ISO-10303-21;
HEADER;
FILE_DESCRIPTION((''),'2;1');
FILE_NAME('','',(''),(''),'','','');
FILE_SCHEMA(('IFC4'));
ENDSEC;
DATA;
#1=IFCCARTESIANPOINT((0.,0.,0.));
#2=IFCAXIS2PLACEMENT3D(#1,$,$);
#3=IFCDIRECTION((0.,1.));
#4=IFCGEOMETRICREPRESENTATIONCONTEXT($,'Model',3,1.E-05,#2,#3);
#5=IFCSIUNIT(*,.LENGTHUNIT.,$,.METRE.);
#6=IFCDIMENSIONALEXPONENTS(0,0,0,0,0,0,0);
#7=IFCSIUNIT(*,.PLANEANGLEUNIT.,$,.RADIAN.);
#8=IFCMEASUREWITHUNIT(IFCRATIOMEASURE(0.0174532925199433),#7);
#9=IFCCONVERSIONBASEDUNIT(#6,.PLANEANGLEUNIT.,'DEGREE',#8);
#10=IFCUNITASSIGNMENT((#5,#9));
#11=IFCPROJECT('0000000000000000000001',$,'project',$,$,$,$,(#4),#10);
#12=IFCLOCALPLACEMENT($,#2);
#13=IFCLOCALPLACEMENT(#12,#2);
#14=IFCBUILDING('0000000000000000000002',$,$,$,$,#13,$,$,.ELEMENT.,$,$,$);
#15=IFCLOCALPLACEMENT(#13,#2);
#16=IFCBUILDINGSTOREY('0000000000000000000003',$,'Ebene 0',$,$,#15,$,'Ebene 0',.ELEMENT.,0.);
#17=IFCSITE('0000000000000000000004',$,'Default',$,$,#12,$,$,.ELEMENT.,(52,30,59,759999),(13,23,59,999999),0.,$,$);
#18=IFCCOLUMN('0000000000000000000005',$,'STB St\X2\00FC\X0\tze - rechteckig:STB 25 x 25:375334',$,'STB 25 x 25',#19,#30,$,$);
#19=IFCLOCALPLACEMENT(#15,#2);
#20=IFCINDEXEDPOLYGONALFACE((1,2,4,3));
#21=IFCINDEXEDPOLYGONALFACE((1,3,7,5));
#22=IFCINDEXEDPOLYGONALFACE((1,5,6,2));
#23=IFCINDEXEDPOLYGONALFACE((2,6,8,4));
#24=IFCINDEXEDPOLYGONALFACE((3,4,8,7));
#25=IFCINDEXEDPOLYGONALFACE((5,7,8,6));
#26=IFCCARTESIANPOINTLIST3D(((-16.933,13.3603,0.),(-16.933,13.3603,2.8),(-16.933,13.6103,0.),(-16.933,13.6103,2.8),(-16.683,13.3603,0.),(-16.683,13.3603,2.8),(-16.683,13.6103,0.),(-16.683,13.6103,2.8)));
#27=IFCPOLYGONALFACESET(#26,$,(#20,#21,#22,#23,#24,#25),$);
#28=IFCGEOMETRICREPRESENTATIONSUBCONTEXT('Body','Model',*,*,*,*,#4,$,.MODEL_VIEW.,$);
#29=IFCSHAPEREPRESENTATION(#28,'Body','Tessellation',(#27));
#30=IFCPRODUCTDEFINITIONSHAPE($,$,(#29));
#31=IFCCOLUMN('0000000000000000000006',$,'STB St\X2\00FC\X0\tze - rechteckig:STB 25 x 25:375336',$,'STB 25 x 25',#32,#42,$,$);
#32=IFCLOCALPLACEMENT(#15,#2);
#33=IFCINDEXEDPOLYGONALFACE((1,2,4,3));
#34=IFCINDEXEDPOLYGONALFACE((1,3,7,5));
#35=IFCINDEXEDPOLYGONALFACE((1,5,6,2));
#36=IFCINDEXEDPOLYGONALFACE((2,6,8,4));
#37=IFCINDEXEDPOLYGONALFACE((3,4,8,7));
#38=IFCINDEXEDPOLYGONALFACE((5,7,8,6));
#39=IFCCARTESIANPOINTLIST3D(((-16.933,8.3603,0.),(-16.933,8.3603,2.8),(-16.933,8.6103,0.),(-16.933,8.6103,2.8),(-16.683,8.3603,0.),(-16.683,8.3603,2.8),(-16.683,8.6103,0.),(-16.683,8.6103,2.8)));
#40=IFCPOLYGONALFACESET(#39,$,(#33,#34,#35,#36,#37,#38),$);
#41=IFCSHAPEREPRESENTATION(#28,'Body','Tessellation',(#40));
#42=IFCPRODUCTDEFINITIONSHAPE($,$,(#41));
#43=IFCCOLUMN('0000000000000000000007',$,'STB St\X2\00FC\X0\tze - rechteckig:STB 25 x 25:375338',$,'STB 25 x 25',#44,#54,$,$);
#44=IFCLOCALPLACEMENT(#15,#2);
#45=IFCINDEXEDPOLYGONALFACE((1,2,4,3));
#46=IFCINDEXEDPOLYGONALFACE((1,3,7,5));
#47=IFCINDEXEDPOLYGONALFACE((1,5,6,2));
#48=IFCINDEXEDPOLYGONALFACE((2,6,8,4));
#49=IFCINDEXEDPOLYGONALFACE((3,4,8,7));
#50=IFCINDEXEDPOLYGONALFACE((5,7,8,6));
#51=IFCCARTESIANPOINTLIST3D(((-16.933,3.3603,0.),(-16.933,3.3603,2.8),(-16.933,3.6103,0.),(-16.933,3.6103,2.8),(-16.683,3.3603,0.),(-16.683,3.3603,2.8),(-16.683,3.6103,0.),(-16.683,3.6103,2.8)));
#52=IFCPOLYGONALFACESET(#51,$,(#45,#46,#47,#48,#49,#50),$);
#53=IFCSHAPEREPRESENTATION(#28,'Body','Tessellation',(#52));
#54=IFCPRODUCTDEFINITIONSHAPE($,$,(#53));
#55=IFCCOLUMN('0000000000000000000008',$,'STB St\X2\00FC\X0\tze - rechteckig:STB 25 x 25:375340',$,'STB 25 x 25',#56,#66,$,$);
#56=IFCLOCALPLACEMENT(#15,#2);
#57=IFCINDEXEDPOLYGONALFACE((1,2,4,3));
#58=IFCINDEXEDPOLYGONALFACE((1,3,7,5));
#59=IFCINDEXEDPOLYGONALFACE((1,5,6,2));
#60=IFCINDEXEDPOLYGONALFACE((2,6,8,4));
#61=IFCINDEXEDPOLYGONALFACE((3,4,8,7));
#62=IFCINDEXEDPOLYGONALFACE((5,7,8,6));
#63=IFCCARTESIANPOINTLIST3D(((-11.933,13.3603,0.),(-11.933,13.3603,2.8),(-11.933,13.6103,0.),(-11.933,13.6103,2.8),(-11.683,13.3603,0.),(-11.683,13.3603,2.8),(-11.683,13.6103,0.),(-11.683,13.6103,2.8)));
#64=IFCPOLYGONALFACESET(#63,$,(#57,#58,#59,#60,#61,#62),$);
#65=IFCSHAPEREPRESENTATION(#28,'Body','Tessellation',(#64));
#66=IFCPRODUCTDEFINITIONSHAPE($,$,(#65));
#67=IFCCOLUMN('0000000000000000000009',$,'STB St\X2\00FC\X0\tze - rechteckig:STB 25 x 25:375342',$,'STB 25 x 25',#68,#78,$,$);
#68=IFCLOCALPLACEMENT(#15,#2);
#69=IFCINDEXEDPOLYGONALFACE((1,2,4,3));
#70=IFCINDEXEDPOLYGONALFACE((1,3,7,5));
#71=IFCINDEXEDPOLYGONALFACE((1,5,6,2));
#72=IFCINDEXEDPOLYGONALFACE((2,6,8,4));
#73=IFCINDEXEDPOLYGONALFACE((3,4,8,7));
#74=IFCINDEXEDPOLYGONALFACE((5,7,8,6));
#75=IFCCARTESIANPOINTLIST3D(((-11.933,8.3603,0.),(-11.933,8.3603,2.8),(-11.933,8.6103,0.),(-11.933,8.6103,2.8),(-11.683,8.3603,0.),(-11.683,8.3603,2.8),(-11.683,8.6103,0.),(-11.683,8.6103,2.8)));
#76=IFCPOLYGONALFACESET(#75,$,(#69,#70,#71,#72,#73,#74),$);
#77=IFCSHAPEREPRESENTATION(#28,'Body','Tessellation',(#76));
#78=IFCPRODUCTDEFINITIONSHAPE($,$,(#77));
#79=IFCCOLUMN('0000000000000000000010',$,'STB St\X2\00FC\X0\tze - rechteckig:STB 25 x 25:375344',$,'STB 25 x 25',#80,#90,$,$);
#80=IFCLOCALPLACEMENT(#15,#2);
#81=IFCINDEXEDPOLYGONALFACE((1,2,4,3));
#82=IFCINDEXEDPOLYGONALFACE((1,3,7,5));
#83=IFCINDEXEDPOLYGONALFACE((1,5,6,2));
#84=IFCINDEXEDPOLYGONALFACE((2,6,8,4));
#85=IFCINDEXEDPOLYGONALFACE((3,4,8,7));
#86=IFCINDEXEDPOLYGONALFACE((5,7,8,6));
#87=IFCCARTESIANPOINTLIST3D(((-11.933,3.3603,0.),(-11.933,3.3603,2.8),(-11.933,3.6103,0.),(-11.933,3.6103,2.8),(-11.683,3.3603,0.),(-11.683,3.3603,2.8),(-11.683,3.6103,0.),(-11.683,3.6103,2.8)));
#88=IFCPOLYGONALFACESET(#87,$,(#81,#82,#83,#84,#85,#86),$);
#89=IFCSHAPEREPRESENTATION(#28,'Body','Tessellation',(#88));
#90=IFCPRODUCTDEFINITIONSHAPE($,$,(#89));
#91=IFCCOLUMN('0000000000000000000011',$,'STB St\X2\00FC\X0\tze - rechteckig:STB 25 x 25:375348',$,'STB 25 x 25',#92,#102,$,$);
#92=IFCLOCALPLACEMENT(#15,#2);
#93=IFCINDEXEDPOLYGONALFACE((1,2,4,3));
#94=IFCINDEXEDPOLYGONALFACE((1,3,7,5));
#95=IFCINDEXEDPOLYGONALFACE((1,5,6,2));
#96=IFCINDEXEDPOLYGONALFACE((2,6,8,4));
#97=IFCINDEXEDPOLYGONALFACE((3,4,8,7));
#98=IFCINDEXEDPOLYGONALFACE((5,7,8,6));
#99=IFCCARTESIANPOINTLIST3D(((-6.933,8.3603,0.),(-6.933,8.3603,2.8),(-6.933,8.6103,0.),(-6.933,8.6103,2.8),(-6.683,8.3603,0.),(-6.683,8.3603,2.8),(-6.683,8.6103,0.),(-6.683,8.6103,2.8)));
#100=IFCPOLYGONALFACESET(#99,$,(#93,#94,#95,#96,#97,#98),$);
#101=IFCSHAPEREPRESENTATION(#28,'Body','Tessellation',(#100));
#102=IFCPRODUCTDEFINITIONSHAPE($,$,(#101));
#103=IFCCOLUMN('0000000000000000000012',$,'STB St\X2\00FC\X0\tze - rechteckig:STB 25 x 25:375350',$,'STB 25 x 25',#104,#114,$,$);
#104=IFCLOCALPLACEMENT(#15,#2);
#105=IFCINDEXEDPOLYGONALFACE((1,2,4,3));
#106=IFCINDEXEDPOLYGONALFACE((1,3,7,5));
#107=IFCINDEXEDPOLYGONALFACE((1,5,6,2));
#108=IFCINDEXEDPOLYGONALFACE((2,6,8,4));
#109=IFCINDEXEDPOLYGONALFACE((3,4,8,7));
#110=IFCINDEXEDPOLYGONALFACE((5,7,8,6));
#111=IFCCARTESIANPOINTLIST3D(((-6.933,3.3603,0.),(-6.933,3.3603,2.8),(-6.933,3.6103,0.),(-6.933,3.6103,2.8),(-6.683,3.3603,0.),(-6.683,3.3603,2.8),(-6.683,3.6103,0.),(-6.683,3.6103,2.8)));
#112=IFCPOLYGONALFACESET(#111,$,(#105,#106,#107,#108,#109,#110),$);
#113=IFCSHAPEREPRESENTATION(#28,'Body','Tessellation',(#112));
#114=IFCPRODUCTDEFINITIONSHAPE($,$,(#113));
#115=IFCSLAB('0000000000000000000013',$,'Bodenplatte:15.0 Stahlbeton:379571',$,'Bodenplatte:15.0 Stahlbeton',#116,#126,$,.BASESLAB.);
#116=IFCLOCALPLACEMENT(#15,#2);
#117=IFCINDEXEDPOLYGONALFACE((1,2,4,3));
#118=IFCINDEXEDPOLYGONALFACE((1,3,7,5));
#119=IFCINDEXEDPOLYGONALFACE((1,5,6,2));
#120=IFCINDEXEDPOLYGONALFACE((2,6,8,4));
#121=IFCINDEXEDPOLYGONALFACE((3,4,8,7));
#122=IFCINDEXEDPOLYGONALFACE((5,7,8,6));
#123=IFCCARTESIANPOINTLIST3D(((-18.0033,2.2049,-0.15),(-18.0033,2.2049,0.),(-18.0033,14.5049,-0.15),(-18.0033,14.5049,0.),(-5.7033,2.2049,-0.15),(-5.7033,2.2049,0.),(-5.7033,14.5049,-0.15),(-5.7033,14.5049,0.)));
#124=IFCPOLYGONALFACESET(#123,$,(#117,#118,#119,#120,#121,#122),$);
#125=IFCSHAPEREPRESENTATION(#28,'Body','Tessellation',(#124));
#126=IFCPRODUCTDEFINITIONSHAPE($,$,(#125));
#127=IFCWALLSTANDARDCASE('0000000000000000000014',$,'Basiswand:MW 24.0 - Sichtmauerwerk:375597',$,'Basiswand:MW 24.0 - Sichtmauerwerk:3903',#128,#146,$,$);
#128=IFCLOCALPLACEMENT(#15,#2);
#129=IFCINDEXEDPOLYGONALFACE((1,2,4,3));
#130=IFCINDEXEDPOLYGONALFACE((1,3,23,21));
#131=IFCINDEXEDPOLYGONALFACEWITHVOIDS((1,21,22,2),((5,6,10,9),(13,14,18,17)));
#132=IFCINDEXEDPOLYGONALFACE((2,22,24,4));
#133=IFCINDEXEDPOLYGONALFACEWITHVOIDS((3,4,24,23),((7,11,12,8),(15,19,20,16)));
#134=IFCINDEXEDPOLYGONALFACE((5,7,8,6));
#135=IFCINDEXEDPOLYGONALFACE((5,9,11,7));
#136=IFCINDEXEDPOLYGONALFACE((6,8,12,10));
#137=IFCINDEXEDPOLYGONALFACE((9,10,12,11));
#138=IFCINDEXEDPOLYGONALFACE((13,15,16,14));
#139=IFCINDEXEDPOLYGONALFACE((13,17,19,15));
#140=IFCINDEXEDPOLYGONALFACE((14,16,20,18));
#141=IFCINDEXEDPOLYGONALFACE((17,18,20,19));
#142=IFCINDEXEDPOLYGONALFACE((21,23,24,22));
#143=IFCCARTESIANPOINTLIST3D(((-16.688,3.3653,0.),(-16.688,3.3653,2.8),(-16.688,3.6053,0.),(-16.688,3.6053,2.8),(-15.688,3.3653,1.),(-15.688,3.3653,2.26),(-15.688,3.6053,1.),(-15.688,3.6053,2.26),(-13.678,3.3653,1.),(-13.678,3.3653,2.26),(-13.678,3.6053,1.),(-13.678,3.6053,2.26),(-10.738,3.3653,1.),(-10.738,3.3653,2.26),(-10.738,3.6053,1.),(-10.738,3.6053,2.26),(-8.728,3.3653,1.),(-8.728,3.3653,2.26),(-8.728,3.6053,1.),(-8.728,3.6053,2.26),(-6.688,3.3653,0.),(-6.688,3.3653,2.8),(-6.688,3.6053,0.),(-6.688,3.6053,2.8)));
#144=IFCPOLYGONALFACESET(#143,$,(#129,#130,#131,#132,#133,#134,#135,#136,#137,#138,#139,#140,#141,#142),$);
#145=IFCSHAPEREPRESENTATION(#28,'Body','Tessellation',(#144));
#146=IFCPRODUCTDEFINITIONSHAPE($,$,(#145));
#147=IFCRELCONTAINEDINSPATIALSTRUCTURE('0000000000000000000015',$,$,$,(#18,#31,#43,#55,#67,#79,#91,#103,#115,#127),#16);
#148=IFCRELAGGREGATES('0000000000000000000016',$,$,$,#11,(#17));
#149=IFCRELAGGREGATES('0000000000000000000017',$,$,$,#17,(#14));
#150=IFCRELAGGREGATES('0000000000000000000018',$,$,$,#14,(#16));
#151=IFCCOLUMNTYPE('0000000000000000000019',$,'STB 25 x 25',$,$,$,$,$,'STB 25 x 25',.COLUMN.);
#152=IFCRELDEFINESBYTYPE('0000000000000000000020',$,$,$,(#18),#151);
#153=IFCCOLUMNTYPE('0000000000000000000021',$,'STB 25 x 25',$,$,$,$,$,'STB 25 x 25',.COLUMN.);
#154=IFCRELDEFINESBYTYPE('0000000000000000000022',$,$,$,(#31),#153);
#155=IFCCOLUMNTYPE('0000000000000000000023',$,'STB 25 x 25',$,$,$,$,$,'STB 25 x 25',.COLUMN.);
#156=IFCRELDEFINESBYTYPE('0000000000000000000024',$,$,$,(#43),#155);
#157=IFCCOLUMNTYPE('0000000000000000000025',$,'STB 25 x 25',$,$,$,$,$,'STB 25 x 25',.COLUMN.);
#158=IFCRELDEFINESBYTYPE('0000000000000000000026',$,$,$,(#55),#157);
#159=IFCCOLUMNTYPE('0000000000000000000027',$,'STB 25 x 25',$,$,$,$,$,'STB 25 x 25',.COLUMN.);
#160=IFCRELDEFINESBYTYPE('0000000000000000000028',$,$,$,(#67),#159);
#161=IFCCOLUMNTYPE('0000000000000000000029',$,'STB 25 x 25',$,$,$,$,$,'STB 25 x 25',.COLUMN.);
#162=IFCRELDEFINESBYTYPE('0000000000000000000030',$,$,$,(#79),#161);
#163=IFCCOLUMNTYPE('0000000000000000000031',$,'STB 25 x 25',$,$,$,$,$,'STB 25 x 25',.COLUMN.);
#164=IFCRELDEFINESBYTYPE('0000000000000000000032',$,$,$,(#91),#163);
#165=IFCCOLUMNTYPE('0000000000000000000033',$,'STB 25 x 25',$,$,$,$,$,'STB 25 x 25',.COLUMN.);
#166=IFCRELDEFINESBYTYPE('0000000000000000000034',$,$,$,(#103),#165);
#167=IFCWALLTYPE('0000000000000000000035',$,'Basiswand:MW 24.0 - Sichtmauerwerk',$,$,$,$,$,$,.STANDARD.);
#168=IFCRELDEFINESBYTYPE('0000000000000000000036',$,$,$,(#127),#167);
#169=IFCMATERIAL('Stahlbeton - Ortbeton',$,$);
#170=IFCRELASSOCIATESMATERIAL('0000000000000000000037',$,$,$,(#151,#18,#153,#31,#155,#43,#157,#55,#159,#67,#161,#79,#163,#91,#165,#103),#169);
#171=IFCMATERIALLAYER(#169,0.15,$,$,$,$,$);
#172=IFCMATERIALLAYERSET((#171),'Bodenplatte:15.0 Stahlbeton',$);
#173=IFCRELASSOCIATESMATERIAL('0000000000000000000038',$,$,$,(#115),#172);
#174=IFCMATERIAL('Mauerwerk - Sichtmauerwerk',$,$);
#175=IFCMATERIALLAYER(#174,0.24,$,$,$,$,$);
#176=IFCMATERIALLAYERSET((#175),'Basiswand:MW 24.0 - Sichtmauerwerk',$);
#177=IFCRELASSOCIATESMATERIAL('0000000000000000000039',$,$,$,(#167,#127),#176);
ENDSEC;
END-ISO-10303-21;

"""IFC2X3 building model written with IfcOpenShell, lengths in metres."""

from ifc_helpers import new_model, entity, si_unit, converted_unit, direction, frame, frame_2d, origin, origin_2d_with_axis, place, context, subcontext, project, spatial, polyline, rectangle, extrude, clip, bounded_halfspace, source, transform, mapped, material, layer, layer_set, layer_usage, type_object, type_shapes, element, save


model = new_model("IFC2X3")

# Units and contexts
model_context = context("Model", 3, precision=1e-05, world=origin(), true_north=direction((0.0, 1.0)))
body_context = subcontext(model_context, "Body", "Model", "MODEL_VIEW")
ifc_project = project(units=[si_unit("LENGTHUNIT", "METRE"), converted_unit("PLANEANGLEUNIT", "DEGREE", entity("IfcRatioMeasure", 0.0174532925199433), si_unit("PLANEANGLEUNIT", "RADIAN"), dimensions=[0, 0, 0, 0, 0, 0, 0])], contexts=[model_context])

# Site, building, storey
site_placement = place(None, origin())
site = spatial("IfcSite", under=ifc_project, at=site_placement, Name="Default", CompositionType="ELEMENT", RefLatitude=(52, 30, 59, 759999), RefLongitude=(13, 23, 59, 999999), RefElevation=0.0)
building_placement = place(site_placement, origin())
building = spatial("IfcBuilding", under=site, at=building_placement, CompositionType="ELEMENT")
storey_placement = place(building_placement, origin())
storey = spatial("IfcBuildingStorey", under=building, at=storey_placement, Name="Ebene 0", LongName="Ebene 0", CompositionType="ELEMENT", Elevation=0.0)

# Columns
ifc_material_1 = material(Name="Stahlbeton - Ortbeton")
column_type_1 = type_object("IfcColumnType", Name="STB 25 x 25", ElementType="STB 25 x 25", PredefinedType="COLUMN", material=ifc_material_1)
shared_shape_1 = source(origin(), body_context, "Body", "SweptSolid", [
    extrude(rectangle(XDim=0.25, YDim=0.25, at=origin_2d_with_axis()), frame((-16.808, 13.4853, 0.0), z_axis=(0.0, 0.0, 1.0), x_axis=(0.0, -1.0, 0.0)), (0.0, 0.0, 1.0), 2.8),
])
type_shapes(column_type_1, [shared_shape_1])
column_1_placement = place(storey_placement, origin())
element("IfcColumn", 1, at=column_1_placement, inside=storey, type_object=column_type_1, material=ifc_material_1, Name="STB Stütze - rechteckig:STB 25 x 25:375334", ObjectType="STB 25 x 25", context=body_context, shape_type="MappedRepresentation", body=[
    mapped(shared_shape_1, transform((0.0, 0.0, 0.0), scale=1.0)),
])
column_type_2 = type_object("IfcColumnType", Name="STB 25 x 25", ElementType="STB 25 x 25", PredefinedType="COLUMN", material=ifc_material_1)
shared_shape_2 = source(origin(), body_context, "Body", "SweptSolid", [
    extrude(rectangle(XDim=0.25, YDim=0.25, at=origin_2d_with_axis()), frame((-16.808, 8.4853, 0.0), z_axis=(0.0, 0.0, 1.0), x_axis=(0.0, -1.0, 0.0)), (0.0, 0.0, 1.0), 2.8),
])
type_shapes(column_type_2, [shared_shape_2])
column_2_placement = place(storey_placement, origin())
element("IfcColumn", 2, at=column_2_placement, inside=storey, type_object=column_type_2, material=ifc_material_1, Name="STB Stütze - rechteckig:STB 25 x 25:375336", ObjectType="STB 25 x 25", context=body_context, shape_type="MappedRepresentation", body=[
    mapped(shared_shape_2, transform((0.0, 0.0, 0.0), scale=1.0)),
])
column_type_3 = type_object("IfcColumnType", Name="STB 25 x 25", ElementType="STB 25 x 25", PredefinedType="COLUMN", material=ifc_material_1)
shared_shape_3 = source(origin(), body_context, "Body", "SweptSolid", [
    extrude(rectangle(XDim=0.25, YDim=0.25, at=frame_2d((0.0, 0.0), x_axis=(1.0, 0.0))), frame((-16.808, 3.4853, 0.0), z_axis=(0.0, 0.0, 1.0), x_axis=(0.0, -1.0, 0.0)), (0.0, 0.0, 1.0), 2.8),
])
type_shapes(column_type_3, [shared_shape_3])
column_3_placement = place(storey_placement, origin())
element("IfcColumn", 3, at=column_3_placement, inside=storey, type_object=column_type_3, material=ifc_material_1, Name="STB Stütze - rechteckig:STB 25 x 25:375338", ObjectType="STB 25 x 25", context=body_context, shape_type="MappedRepresentation", body=[
    mapped(shared_shape_3, transform((0.0, 0.0, 0.0), scale=1.0)),
])
column_type_4 = type_object("IfcColumnType", Name="STB 25 x 25", ElementType="STB 25 x 25", PredefinedType="COLUMN", material=ifc_material_1)
shared_shape_4 = source(origin(), body_context, "Body", "SweptSolid", [
    extrude(rectangle(XDim=0.25, YDim=0.25, at=origin_2d_with_axis()), frame((-11.808, 13.4853, 0.0), z_axis=(0.0, 0.0, 1.0), x_axis=(0.0, -1.0, 0.0)), (0.0, 0.0, 1.0), 2.8),
])
type_shapes(column_type_4, [shared_shape_4])
column_4_placement = place(storey_placement, origin())
element("IfcColumn", 4, at=column_4_placement, inside=storey, type_object=column_type_4, material=ifc_material_1, Name="STB Stütze - rechteckig:STB 25 x 25:375340", ObjectType="STB 25 x 25", context=body_context, shape_type="MappedRepresentation", body=[
    mapped(shared_shape_4, transform((0.0, 0.0, 0.0), scale=1.0)),
])
column_type_5 = type_object("IfcColumnType", Name="STB 25 x 25", ElementType="STB 25 x 25", PredefinedType="COLUMN", material=ifc_material_1)
shared_shape_5 = source(origin(), body_context, "Body", "SweptSolid", [
    extrude(rectangle(XDim=0.25, YDim=0.25, at=origin_2d_with_axis()), frame((-11.808, 8.4853, 0.0), z_axis=(0.0, 0.0, 1.0), x_axis=(0.0, -1.0, 0.0)), (0.0, 0.0, 1.0), 2.8),
])
type_shapes(column_type_5, [shared_shape_5])
column_5_placement = place(storey_placement, origin())
element("IfcColumn", 5, at=column_5_placement, inside=storey, type_object=column_type_5, material=ifc_material_1, Name="STB Stütze - rechteckig:STB 25 x 25:375342", ObjectType="STB 25 x 25", context=body_context, shape_type="MappedRepresentation", body=[
    mapped(shared_shape_5, transform((0.0, 0.0, 0.0), scale=1.0)),
])
column_type_6 = type_object("IfcColumnType", Name="STB 25 x 25", ElementType="STB 25 x 25", PredefinedType="COLUMN", material=ifc_material_1)
shared_shape_6 = source(origin(), body_context, "Body", "SweptSolid", [
    extrude(rectangle(XDim=0.25, YDim=0.25, at=frame_2d((0.0, 0.0), x_axis=(1.0, 0.0))), frame((-11.808, 3.4853, 0.0), z_axis=(0.0, 0.0, 1.0), x_axis=(0.0, -1.0, 0.0)), (0.0, 0.0, 1.0), 2.8),
])
type_shapes(column_type_6, [shared_shape_6])
column_6_placement = place(storey_placement, origin())
element("IfcColumn", 6, at=column_6_placement, inside=storey, type_object=column_type_6, material=ifc_material_1, Name="STB Stütze - rechteckig:STB 25 x 25:375344", ObjectType="STB 25 x 25", context=body_context, shape_type="MappedRepresentation", body=[
    mapped(shared_shape_6, transform((0.0, 0.0, 0.0), scale=1.0)),
])
column_type_7 = type_object("IfcColumnType", Name="STB 25 x 25", ElementType="STB 25 x 25", PredefinedType="COLUMN", material=ifc_material_1)
shared_shape_7 = source(origin(), body_context, "Body", "SweptSolid", [
    extrude(rectangle(XDim=0.25, YDim=0.25, at=origin_2d_with_axis()), frame((-6.808, 8.4853, 0.0), z_axis=(0.0, 0.0, 1.0), x_axis=(0.0, -1.0, 0.0)), (0.0, 0.0, 1.0), 2.8),
])
type_shapes(column_type_7, [shared_shape_7])
column_7_placement = place(storey_placement, origin())
element("IfcColumn", 7, at=column_7_placement, inside=storey, type_object=column_type_7, material=ifc_material_1, Name="STB Stütze - rechteckig:STB 25 x 25:375348", ObjectType="STB 25 x 25", context=body_context, shape_type="MappedRepresentation", body=[
    mapped(shared_shape_7, transform((0.0, 0.0, 0.0), scale=1.0)),
])
column_type_8 = type_object("IfcColumnType", Name="STB 25 x 25", ElementType="STB 25 x 25", PredefinedType="COLUMN", material=ifc_material_1)
shared_shape_8 = source(origin(), body_context, "Body", "SweptSolid", [
    extrude(rectangle(XDim=0.25, YDim=0.25, at=frame_2d((0.0, 0.0), x_axis=(1.0, 0.0))), frame((-6.808, 3.4853, 0.0), z_axis=(0.0, 0.0, 1.0), x_axis=(0.0, -1.0, 0.0)), (0.0, 0.0, 1.0), 2.8),
])
type_shapes(column_type_8, [shared_shape_8])
column_8_placement = place(storey_placement, origin())
element("IfcColumn", 8, at=column_8_placement, inside=storey, type_object=column_type_8, material=ifc_material_1, Name="STB Stütze - rechteckig:STB 25 x 25:375350", ObjectType="STB 25 x 25", context=body_context, shape_type="MappedRepresentation", body=[
    mapped(shared_shape_8, transform((0.0, 0.0, 0.0), scale=1.0)),
])

# Slab
ifc_layer_1 = layer(ifc_material_1, 0.15)
ifc_layer_set_1 = layer_set([ifc_layer_1], Name="Bodenplatte:15.0 Stahlbeton")
ifc_layer_usage_1 = layer_usage(ifc_layer_set_1, "AXIS3", "POSITIVE", 0.0)
slab_placement = place(storey_placement, origin())
element("IfcSlab", 9, at=slab_placement, inside=storey, material=ifc_layer_usage_1, Name="Bodenplatte:15.0 Stahlbeton:379571", ObjectType="Bodenplatte:15.0 Stahlbeton", PredefinedType="BASESLAB", context=body_context, shape_type="SweptSolid", body=[
    extrude(rectangle(XDim=12.3, YDim=12.3, at=origin_2d_with_axis()), frame((-11.8533, 8.3549, 0.0), z_axis=(0.0, 0.0, -1.0), x_axis=(0.0, 1.0, 0.0)), (0.0, 0.0, 1.0), 0.15),
])

# Wall, openings
ifc_material_2 = material(Name="Mauerwerk - Sichtmauerwerk")
ifc_layer_2 = layer(ifc_material_2, 0.24)
ifc_layer_set_2 = layer_set([ifc_layer_2], Name="Basiswand:MW 24.0 - Sichtmauerwerk")
ifc_layer_usage_2 = layer_usage(ifc_layer_set_2, "AXIS2", "NEGATIVE", 0.12)
wall_type_1 = type_object("IfcWallType", Name="Basiswand:MW 24.0 - Sichtmauerwerk", PredefinedType="STANDARD", material=ifc_layer_set_2)
wall_1_placement = place(storey_placement, frame((-16.688, 3.4853, 0.0)))
wall_1 = element("IfcWallStandardCase", 10, at=wall_1_placement, inside=storey, type_object=wall_type_1, material=ifc_layer_usage_2, Name="Basiswand:MW 24.0 - Sichtmauerwerk:375597", ObjectType="Basiswand:MW 24.0 - Sichtmauerwerk:3903", context=body_context, shape_type="Clipping", body=[
    clip(extrude(rectangle(XDim=10.0, YDim=0.24, at=frame_2d((5.0, 0.0), x_axis=(-1.0, 0.0))), origin(), (0.0, 0.0, 1.0), 2.8), bounded_halfspace(frame((0.0, -0.12, 2.8), z_axis=(0.0, 0.0, -1.0), x_axis=(-1.0, 0.0, 0.0)), True, frame((0.0, -0.12, 2.8)), polyline([(0.0, 0.0), (10.0, 0.0), (10.0, 0.24), (9.76, 0.24), (0.0, 0.24), (0.0, 0.0)]))),
])
opening_1_placement = place(wall_1_placement, frame((1.0, -0.12, 1.0)))
element("IfcOpeningElement", 11, at=opening_1_placement, cuts=wall_1, ObjectType="Opening", context=body_context, shape_type="SweptSolid", body=[
    extrude(rectangle(XDim=1.26, YDim=2.01, at=frame_2d((0.63, 1.005), x_axis=(1.0, 0.0))), frame((0.0, 0.0, 0.0), z_axis=(0.0, 1.0, 0.0), x_axis=(0.0, 0.0, 1.0)), (0.0, 0.0, 1.0), 0.24),
])
opening_2_placement = place(wall_1_placement, frame((5.95, -0.12, 1.0)))
element("IfcOpeningElement", 12, at=opening_2_placement, cuts=wall_1, ObjectType="Opening", context=body_context, shape_type="SweptSolid", body=[
    extrude(rectangle(XDim=1.26, YDim=2.01, at=frame_2d((0.63, 1.005), x_axis=(1.0, 0.0))), frame((0.0, 0.0, 0.0), z_axis=(0.0, 1.0, 0.0), x_axis=(0.0, 0.0, 1.0)), (0.0, 0.0, 1.0), 0.24),
])

save(model, "model.ifc")
